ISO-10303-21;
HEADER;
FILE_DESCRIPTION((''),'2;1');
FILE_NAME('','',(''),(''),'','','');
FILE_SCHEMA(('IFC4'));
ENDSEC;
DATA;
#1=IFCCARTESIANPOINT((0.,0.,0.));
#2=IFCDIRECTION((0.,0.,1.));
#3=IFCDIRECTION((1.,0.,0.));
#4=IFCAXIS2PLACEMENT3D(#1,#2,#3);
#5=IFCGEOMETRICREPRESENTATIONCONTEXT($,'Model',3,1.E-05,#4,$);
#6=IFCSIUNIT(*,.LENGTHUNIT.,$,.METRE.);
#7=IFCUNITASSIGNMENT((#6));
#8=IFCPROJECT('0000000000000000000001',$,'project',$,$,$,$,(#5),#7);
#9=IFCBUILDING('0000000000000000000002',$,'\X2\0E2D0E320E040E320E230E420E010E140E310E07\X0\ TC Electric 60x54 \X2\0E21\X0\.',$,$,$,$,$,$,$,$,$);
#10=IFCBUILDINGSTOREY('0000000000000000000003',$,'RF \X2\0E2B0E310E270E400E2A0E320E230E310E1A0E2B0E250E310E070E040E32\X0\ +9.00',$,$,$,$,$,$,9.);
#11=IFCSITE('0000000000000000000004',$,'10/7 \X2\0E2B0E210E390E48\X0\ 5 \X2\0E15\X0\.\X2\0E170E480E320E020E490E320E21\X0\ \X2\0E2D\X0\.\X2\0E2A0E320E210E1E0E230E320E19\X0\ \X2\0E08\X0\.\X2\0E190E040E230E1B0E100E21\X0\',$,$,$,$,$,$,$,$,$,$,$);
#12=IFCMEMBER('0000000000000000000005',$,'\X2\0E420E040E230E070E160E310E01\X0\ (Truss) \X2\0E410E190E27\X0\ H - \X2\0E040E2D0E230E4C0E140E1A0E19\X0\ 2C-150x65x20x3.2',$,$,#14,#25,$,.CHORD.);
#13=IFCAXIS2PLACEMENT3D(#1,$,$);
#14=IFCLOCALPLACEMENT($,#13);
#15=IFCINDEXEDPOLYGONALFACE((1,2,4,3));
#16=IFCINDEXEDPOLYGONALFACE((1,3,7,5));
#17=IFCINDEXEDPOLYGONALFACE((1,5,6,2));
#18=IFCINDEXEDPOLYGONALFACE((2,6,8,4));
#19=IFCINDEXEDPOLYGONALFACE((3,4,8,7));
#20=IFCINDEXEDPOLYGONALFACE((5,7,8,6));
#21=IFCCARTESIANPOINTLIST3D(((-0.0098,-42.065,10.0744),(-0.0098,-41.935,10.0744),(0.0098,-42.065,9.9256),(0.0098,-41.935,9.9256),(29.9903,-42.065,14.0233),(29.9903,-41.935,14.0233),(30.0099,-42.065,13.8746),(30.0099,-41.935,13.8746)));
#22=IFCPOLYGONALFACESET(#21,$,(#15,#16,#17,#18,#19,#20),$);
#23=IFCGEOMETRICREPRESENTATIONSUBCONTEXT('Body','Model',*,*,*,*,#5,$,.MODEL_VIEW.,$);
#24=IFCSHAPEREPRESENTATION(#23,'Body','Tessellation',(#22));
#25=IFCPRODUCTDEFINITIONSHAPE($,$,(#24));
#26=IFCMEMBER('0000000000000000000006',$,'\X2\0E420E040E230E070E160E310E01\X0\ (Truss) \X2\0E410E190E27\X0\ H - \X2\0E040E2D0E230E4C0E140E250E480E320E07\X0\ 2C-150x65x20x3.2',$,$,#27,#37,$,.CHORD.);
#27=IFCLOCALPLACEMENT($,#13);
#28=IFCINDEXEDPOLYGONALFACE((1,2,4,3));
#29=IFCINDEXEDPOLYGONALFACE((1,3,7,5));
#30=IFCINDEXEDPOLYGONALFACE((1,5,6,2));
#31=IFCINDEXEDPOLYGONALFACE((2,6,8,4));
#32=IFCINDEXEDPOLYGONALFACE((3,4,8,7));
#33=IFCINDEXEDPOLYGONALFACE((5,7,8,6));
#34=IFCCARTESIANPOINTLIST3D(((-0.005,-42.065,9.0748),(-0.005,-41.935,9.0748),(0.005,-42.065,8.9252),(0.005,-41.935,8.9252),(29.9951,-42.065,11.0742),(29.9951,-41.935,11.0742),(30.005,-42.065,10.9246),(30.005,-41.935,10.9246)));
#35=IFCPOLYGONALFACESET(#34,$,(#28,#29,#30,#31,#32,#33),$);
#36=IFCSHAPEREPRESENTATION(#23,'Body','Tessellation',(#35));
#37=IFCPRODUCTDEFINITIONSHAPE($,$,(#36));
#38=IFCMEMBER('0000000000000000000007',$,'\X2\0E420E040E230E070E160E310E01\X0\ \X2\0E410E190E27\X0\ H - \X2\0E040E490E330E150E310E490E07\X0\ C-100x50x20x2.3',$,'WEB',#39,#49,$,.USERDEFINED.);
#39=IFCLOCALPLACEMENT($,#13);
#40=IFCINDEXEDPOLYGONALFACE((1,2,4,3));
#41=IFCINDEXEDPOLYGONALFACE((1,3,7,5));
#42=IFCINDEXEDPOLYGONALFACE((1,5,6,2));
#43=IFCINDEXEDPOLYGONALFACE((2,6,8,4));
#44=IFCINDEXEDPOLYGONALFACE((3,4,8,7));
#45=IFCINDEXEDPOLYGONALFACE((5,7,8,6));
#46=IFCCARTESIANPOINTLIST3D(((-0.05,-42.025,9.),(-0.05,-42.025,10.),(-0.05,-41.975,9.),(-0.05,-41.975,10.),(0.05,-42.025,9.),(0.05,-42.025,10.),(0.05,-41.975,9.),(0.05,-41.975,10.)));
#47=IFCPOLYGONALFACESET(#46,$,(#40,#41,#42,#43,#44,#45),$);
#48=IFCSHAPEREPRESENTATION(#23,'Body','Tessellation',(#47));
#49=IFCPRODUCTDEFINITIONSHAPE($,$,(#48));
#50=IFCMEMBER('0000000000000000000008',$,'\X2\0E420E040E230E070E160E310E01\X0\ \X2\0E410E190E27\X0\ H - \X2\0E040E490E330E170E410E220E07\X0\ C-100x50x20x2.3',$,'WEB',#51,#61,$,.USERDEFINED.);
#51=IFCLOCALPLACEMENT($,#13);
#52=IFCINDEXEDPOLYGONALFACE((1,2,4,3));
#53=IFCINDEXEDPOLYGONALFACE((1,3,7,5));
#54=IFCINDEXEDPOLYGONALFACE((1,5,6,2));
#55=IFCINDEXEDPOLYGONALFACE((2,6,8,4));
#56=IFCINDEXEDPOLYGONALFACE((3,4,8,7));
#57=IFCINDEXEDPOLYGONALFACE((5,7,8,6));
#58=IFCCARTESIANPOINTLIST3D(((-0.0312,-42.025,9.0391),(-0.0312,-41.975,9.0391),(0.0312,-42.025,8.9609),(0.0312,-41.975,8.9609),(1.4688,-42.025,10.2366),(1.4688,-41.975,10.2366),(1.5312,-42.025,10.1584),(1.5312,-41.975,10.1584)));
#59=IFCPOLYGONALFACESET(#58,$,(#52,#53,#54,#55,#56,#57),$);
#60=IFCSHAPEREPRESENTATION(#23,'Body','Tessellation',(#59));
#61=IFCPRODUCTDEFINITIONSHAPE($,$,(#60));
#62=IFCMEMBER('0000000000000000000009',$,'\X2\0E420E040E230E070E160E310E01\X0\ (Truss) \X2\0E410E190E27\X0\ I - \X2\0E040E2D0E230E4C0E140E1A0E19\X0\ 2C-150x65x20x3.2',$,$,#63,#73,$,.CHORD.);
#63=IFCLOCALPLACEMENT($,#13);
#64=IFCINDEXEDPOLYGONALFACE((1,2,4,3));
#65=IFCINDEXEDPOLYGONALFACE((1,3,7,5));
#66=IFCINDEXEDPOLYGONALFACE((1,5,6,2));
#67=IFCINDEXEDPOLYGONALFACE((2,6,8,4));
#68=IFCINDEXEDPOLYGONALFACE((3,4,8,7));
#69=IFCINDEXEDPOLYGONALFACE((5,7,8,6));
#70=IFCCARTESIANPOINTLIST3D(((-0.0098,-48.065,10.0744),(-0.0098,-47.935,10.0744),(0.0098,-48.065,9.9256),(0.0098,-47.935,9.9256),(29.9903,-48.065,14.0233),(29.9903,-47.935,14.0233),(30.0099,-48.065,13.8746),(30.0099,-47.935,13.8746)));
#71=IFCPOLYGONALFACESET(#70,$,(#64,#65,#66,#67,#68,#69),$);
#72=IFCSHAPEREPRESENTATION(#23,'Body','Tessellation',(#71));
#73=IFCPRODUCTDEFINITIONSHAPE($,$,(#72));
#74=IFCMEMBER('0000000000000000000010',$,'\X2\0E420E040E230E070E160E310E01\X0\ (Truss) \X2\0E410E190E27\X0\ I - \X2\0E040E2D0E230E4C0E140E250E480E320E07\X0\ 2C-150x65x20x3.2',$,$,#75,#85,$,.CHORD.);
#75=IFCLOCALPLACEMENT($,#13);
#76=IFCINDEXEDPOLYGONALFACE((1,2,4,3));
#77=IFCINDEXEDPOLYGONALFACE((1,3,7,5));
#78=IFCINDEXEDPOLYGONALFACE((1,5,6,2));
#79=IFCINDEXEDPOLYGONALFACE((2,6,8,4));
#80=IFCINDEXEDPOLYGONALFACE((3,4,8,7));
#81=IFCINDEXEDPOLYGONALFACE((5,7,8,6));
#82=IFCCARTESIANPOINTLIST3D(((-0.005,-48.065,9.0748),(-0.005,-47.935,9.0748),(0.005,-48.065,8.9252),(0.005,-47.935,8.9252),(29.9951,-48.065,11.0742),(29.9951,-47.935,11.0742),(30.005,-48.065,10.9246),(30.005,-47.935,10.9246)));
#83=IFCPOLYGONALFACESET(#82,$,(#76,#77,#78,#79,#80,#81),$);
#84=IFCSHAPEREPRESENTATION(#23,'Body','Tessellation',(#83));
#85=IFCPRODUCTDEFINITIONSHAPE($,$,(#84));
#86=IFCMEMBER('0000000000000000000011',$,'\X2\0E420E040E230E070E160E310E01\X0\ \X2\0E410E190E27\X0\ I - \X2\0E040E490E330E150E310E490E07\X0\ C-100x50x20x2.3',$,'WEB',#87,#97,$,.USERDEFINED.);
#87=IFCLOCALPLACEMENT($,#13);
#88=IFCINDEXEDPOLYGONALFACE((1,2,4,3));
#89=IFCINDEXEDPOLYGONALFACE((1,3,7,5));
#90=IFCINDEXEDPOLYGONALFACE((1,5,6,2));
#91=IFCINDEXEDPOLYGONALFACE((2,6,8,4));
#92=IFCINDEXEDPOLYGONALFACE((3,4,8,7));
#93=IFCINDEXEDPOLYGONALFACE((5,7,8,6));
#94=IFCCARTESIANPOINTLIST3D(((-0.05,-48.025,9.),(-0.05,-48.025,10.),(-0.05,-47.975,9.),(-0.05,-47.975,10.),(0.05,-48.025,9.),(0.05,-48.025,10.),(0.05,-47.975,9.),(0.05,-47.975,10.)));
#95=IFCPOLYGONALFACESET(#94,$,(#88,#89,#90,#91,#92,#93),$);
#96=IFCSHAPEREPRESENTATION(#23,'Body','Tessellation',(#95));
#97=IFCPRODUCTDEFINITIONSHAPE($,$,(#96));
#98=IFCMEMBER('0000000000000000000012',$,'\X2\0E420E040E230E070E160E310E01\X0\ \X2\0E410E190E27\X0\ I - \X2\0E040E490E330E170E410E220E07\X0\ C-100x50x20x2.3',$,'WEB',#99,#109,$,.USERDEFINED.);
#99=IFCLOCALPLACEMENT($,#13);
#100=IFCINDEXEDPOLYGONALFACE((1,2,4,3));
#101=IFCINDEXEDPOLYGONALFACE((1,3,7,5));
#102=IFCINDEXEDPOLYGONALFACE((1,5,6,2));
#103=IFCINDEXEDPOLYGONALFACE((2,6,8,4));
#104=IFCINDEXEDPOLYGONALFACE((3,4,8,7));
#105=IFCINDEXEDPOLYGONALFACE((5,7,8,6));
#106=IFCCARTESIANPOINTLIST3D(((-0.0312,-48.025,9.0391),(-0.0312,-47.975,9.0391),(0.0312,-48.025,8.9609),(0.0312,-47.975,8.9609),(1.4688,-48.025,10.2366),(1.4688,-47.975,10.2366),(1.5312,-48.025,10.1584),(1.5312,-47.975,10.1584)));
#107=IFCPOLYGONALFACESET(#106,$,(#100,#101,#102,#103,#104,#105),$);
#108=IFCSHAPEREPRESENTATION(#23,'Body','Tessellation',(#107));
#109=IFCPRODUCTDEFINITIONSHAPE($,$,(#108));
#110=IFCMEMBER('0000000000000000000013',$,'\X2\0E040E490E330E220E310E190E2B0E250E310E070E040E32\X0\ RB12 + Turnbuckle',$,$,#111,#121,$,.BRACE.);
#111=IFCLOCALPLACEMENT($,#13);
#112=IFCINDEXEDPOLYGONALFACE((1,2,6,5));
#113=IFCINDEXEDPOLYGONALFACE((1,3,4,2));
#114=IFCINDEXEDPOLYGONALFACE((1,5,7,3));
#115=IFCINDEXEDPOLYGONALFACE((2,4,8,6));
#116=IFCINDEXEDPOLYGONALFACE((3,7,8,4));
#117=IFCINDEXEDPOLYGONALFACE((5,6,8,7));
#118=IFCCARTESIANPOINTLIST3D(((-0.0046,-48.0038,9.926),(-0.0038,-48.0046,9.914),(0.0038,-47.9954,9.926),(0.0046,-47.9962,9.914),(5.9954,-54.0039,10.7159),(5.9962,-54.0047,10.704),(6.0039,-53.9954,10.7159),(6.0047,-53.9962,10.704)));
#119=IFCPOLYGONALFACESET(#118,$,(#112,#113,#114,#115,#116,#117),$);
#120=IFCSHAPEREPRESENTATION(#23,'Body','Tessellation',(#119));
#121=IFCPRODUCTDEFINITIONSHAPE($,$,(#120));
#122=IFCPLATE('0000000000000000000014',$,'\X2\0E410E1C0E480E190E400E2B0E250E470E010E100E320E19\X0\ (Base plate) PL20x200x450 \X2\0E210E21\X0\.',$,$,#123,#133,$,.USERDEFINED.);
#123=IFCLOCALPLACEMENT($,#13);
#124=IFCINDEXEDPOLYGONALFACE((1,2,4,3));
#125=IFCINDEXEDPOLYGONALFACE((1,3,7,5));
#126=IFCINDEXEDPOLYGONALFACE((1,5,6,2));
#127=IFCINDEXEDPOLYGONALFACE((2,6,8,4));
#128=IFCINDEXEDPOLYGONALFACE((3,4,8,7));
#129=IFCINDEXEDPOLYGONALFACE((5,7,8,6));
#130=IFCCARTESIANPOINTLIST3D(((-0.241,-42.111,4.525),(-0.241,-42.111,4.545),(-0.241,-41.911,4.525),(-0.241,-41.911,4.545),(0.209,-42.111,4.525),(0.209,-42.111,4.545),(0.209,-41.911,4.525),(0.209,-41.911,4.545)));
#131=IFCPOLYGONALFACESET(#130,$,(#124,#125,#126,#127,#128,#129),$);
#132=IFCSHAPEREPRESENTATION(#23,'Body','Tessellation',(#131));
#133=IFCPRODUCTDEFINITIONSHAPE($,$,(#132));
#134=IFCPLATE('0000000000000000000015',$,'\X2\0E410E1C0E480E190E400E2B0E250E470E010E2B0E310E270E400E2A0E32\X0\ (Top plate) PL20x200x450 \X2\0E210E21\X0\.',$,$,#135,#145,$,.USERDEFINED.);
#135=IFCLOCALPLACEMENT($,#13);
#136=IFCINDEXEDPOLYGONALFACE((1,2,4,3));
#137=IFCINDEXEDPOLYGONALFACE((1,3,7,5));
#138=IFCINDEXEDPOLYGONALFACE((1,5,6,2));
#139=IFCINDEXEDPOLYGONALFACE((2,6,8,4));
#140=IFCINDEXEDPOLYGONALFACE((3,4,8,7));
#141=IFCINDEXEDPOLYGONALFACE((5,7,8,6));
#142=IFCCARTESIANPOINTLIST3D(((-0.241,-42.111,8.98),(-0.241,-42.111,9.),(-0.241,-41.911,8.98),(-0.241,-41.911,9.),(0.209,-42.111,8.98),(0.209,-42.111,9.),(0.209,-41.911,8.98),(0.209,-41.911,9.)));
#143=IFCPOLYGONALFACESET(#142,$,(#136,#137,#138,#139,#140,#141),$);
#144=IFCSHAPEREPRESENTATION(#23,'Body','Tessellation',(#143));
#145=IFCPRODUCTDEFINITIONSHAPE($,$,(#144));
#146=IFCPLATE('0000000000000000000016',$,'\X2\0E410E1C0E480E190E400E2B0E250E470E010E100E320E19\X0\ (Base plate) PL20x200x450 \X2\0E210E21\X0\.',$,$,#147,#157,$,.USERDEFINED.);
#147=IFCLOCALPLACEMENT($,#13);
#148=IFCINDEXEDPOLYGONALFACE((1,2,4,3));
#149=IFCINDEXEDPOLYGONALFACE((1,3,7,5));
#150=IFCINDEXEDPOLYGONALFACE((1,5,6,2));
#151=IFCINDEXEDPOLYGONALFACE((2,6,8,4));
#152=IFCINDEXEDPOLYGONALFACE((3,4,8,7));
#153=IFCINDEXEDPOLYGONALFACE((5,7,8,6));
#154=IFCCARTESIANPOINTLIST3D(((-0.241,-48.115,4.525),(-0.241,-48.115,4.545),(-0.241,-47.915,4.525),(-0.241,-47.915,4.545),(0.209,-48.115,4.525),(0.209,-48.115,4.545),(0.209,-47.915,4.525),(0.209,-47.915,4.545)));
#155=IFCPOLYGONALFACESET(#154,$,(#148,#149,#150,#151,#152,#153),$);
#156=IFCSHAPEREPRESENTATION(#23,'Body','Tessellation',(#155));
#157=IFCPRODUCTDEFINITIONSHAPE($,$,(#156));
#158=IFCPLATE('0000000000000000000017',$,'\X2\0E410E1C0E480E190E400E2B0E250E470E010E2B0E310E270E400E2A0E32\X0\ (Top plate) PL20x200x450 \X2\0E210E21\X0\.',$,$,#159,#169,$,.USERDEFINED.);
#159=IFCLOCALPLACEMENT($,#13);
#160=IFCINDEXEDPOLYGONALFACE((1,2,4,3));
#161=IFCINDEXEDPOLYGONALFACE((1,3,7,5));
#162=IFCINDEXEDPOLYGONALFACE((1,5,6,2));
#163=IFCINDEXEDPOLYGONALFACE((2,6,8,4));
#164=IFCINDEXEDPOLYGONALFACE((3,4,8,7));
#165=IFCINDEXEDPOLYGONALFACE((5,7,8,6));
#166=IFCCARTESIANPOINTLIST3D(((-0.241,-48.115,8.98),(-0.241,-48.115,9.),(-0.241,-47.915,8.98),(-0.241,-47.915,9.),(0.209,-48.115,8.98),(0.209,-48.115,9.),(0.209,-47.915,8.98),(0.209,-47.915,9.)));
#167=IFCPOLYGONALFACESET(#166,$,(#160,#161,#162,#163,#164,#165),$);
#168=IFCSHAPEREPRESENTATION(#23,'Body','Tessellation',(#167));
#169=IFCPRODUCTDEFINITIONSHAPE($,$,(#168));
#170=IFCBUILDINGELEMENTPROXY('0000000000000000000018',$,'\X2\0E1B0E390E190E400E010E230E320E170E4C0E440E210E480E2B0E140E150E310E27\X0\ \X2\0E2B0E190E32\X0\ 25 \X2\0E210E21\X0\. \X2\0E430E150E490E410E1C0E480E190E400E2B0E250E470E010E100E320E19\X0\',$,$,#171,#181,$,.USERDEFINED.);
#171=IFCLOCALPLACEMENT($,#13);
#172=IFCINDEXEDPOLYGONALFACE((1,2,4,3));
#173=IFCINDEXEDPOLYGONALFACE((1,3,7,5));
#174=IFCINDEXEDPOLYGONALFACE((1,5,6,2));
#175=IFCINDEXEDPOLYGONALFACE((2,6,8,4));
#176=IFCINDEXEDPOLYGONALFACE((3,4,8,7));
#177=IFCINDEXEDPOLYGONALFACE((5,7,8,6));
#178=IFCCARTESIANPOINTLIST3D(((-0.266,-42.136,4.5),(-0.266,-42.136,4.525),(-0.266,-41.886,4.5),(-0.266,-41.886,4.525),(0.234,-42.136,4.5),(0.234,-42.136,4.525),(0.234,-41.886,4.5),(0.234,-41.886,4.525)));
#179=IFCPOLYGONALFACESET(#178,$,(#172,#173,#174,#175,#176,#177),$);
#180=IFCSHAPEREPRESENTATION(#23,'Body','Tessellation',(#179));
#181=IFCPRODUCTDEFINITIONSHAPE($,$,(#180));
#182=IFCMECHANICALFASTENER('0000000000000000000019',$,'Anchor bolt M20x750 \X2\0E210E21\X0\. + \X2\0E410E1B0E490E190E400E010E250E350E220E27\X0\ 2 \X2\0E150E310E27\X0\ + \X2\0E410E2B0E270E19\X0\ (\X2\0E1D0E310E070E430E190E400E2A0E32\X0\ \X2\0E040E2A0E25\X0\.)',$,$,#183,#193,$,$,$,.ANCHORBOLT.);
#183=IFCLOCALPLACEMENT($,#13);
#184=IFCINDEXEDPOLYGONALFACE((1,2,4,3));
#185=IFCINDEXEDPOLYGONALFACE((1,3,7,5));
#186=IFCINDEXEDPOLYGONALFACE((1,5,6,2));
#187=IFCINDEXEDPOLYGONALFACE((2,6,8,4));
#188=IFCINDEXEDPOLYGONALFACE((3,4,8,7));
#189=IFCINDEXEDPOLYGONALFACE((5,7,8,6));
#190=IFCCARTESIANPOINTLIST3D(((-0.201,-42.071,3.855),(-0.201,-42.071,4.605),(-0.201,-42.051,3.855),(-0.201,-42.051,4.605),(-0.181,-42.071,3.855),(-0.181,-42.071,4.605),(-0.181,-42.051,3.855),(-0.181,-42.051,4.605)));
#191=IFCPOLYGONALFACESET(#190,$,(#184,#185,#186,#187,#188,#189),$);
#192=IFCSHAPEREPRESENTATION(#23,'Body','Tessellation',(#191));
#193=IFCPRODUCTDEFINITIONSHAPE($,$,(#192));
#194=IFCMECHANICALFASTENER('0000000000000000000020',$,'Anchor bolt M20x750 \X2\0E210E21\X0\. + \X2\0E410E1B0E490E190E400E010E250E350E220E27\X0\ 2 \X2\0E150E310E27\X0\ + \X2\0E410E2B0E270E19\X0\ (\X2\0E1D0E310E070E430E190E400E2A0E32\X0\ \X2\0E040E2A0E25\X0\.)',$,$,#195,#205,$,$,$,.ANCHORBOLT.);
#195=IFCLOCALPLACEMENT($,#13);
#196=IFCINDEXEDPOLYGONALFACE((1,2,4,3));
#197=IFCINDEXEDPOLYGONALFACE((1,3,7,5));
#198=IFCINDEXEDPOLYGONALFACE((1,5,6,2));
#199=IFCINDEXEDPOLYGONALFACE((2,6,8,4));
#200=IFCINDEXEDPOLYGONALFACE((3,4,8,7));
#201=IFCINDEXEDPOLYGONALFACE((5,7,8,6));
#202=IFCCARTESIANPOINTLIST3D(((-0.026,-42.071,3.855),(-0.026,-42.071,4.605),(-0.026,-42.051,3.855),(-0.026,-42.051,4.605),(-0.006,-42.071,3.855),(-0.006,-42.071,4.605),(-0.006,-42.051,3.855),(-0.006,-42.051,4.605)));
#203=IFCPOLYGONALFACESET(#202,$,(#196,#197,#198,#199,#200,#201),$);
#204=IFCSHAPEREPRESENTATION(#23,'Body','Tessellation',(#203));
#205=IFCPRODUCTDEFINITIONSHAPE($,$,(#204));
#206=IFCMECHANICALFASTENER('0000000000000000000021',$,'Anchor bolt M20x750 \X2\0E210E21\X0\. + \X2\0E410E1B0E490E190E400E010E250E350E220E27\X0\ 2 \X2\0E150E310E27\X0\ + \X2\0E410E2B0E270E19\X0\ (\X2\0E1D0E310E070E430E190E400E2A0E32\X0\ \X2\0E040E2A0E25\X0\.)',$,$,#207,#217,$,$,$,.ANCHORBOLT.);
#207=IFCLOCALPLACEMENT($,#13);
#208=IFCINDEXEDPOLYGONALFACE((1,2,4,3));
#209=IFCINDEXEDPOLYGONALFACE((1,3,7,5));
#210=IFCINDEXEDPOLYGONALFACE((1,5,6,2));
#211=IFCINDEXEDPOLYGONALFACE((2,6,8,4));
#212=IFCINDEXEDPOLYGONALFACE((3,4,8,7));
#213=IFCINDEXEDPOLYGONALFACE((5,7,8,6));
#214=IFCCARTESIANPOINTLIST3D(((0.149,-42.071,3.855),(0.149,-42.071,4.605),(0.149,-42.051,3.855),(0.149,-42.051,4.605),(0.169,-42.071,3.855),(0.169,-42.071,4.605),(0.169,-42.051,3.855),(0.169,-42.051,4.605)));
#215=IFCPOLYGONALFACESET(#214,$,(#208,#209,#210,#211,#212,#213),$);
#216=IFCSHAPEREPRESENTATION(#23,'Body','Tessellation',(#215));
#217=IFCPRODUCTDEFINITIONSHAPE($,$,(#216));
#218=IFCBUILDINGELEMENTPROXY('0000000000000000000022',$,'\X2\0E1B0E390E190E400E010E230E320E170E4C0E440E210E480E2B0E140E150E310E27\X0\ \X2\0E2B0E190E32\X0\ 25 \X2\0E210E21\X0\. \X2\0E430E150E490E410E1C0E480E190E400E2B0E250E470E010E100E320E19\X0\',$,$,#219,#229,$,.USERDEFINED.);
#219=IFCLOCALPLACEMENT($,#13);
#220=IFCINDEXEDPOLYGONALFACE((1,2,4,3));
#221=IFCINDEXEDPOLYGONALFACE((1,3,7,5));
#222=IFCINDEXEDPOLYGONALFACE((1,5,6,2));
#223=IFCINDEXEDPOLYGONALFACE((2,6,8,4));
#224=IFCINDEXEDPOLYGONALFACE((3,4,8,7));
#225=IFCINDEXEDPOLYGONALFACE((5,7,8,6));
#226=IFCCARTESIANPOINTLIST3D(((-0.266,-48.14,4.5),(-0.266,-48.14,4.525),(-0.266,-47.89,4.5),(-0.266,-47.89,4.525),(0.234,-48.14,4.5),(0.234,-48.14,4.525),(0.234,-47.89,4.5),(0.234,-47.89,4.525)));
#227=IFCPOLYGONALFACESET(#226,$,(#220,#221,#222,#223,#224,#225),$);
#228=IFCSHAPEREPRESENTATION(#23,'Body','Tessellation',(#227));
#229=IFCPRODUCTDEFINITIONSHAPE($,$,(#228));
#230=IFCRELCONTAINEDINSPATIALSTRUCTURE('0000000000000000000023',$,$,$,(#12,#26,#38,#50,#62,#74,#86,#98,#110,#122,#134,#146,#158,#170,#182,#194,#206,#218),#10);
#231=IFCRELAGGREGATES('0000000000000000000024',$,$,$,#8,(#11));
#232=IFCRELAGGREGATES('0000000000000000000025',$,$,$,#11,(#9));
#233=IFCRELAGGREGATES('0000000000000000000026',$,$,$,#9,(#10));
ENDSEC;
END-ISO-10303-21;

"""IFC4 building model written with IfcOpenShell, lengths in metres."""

from ifc_helpers import new_model, si_unit, frame, origin, origin_with_axes, origin_2d, place, context, subcontext, project, spatial, rectangle, extrude, element, save


model = new_model("IFC4")

# Units and contexts
model_context = context("Model", 3, precision=1e-05, world=origin_with_axes())
body_context = subcontext(model_context, "Body", "Model", "MODEL_VIEW")
ifc_project = project(units=[si_unit("LENGTHUNIT", "METRE")], contexts=[model_context])

# Site, building, storey
site = spatial("IfcSite", under=ifc_project, Name="10/7 หมู่ 5 ต.ท่าข้าม อ.สามพราน จ.นครปฐม")
building = spatial("IfcBuilding", under=site, Name="อาคารโกดัง TC Electric 60x54 ม.")
storey = spatial("IfcBuildingStorey", under=building, Name="RF หัวเสารับหลังคา +9.00", Elevation=9.0)

# Members
member_1_placement = place(None, frame((0.0, -42.0, 10.0), z_axis=(0.9914, 0.0, 0.1305), x_axis=(0.0, -1.0, 0.0)))
element("IfcMember", 1, at=member_1_placement, inside=storey, Name="โครงถัก (Truss) แนว H - คอร์ดบน 2C-150x65x20x3.2", PredefinedType="CHORD", context=body_context, shape_type="SweptSolid", body=[
    extrude(rectangle(XDim=0.13, YDim=0.15, at=origin_2d()), origin(), (0.0, 0.0, 1.0), 30.2589),
])
member_2_placement = place(None, frame((0.0, -42.0, 9.0), z_axis=(0.9978, 0.0, 0.0665), x_axis=(0.0, -1.0, 0.0)))
element("IfcMember", 2, at=member_2_placement, inside=storey, Name="โครงถัก (Truss) แนว H - คอร์ดล่าง 2C-150x65x20x3.2", PredefinedType="CHORD", context=body_context, shape_type="SweptSolid", body=[
    extrude(rectangle(XDim=0.13, YDim=0.15, at=origin_2d()), origin(), (0.0, 0.0, 1.0), 30.0666),
])
member_3_placement = place(None, frame((0.0, -42.0, 9.0), z_axis=(0.0, 0.0, 1.0), x_axis=(0.0, 1.0, 0.0)))
element("IfcMember", 3, at=member_3_placement, inside=storey, Name="โครงถัก แนว H - ค้ำตั้ง C-100x50x20x2.3", ObjectType="WEB", PredefinedType="USERDEFINED", context=body_context, shape_type="SweptSolid", body=[
    extrude(rectangle(XDim=0.05, YDim=0.1, at=origin_2d()), origin(), (0.0, 0.0, 1.0), 1.0),
])
member_4_placement = place(None, frame((0.0, -42.0, 9.0), z_axis=(0.7815, 0.0, 0.6239), x_axis=(0.0, -1.0, 0.0)))
element("IfcMember", 4, at=member_4_placement, inside=storey, Name="โครงถัก แนว H - ค้ำทแยง C-100x50x20x2.3", ObjectType="WEB", PredefinedType="USERDEFINED", context=body_context, shape_type="SweptSolid", body=[
    extrude(rectangle(XDim=0.05, YDim=0.1, at=origin_2d()), origin(), (0.0, 0.0, 1.0), 1.9194),
])
member_5_placement = place(None, frame((0.0, -48.0, 10.0), z_axis=(0.9914, 0.0, 0.1305), x_axis=(0.0, -1.0, 0.0)))
element("IfcMember", 5, at=member_5_placement, inside=storey, Name="โครงถัก (Truss) แนว I - คอร์ดบน 2C-150x65x20x3.2", PredefinedType="CHORD", context=body_context, shape_type="SweptSolid", body=[
    extrude(rectangle(XDim=0.13, YDim=0.15, at=origin_2d()), origin(), (0.0, 0.0, 1.0), 30.2589),
])
member_6_placement = place(None, frame((0.0, -48.0, 9.0), z_axis=(0.9978, 0.0, 0.0665), x_axis=(0.0, -1.0, 0.0)))
element("IfcMember", 6, at=member_6_placement, inside=storey, Name="โครงถัก (Truss) แนว I - คอร์ดล่าง 2C-150x65x20x3.2", PredefinedType="CHORD", context=body_context, shape_type="SweptSolid", body=[
    extrude(rectangle(XDim=0.13, YDim=0.15, at=origin_2d()), origin(), (0.0, 0.0, 1.0), 30.0666),
])
member_7_placement = place(None, frame((0.0, -48.0, 9.0), z_axis=(0.0, 0.0, 1.0), x_axis=(0.0, 1.0, 0.0)))
element("IfcMember", 7, at=member_7_placement, inside=storey, Name="โครงถัก แนว I - ค้ำตั้ง C-100x50x20x2.3", ObjectType="WEB", PredefinedType="USERDEFINED", context=body_context, shape_type="SweptSolid", body=[
    extrude(rectangle(XDim=0.05, YDim=0.1, at=origin_2d()), origin(), (0.0, 0.0, 1.0), 1.0),
])
member_8_placement = place(None, frame((0.0, -48.0, 9.0), z_axis=(0.7815, 0.0, 0.6239), x_axis=(0.0, -1.0, 0.0)))
element("IfcMember", 8, at=member_8_placement, inside=storey, Name="โครงถัก แนว I - ค้ำทแยง C-100x50x20x2.3", ObjectType="WEB", PredefinedType="USERDEFINED", context=body_context, shape_type="SweptSolid", body=[
    extrude(rectangle(XDim=0.05, YDim=0.1, at=origin_2d()), origin(), (0.0, 0.0, 1.0), 1.9194),
])
member_9_placement = place(None, frame((0.0, -48.0, 9.92), z_axis=(0.7041, -0.7041, 0.0927), x_axis=(-0.7071, -0.7071, 0.0)))
element("IfcMember", 9, at=member_9_placement, inside=storey, Name="ค้ำยันหลังคา RB12 + Turnbuckle", PredefinedType="BRACE", context=body_context, shape_type="SweptSolid", body=[
    extrude(rectangle(XDim=0.012, YDim=0.012, at=origin_2d()), origin(), (0.0, 0.0, 1.0), 8.522),
])

# Plates
for number, where, z_axis, x_axis, name in (
    (10, (-0.016, -42.011, 4.525), (0.0, 0.0, 1.0), (1.0, 0.0, 0.0), "แผ่นเหล็กฐาน (Base plate) PL20x200x450 มม."),
    (11, (-0.016, -42.011, 8.98), (0.0, 0.0, 1.0), (1.0, 0.0, 0.0), "แผ่นเหล็กหัวเสา (Top plate) PL20x200x450 มม."),
    (12, (-0.016, -48.015, 4.525), (0.0, 0.0, 1.0), (1.0, 0.0, 0.0), "แผ่นเหล็กฐาน (Base plate) PL20x200x450 มม."),
    (13, (-0.016, -48.015, 8.98), (0.0, 0.0, 1.0), (1.0, 0.0, 0.0), "แผ่นเหล็กหัวเสา (Top plate) PL20x200x450 มม."),
):
    element("IfcPlate", number, at=place(None, frame(where, z_axis=z_axis, x_axis=x_axis)), inside=storey, Name=name, PredefinedType="USERDEFINED", context=body_context, shape_type="SweptSolid", body=[
        extrude(rectangle(XDim=0.45, YDim=0.2, at=origin_2d()), origin(), (0.0, 0.0, 1.0), 0.02),
    ])

# Building element proxy
proxy_1_placement = place(None, frame((-0.016, -42.011, 4.5), z_axis=(0.0, 0.0, 1.0), x_axis=(1.0, 0.0, 0.0)))
element("IfcBuildingElementProxy", 14, at=proxy_1_placement, inside=storey, Name="ปูนเกราท์ไม่หดตัว หนา 25 มม. ใต้แผ่นเหล็กฐาน", PredefinedType="USERDEFINED", context=body_context, shape_type="SweptSolid", body=[
    extrude(rectangle(XDim=0.5, YDim=0.25, at=origin_2d()), origin(), (0.0, 0.0, 1.0), 0.025),
])

# Mechanical fasteners
for number, where, z_axis, x_axis, name in (
    (15, (-0.191, -42.061, 3.855), (0.0, 0.0, 1.0), (1.0, 0.0, 0.0), "Anchor bolt M20x750 มม. + แป้นเกลียว 2 ตัว + แหวน (ฝังในเสา คสล.)"),
    (16, (-0.016, -42.061, 3.855), (0.0, 0.0, 1.0), (1.0, 0.0, 0.0), "Anchor bolt M20x750 มม. + แป้นเกลียว 2 ตัว + แหวน (ฝังในเสา คสล.)"),
    (17, (0.159, -42.061, 3.855), (0.0, 0.0, 1.0), (1.0, 0.0, 0.0), "Anchor bolt M20x750 มม. + แป้นเกลียว 2 ตัว + แหวน (ฝังในเสา คสล.)"),
):
    element("IfcMechanicalFastener", number, at=place(None, frame(where, z_axis=z_axis, x_axis=x_axis)), inside=storey, Name=name, PredefinedType="ANCHORBOLT", context=body_context, shape_type="SweptSolid", body=[
        extrude(rectangle(XDim=0.02, YDim=0.02, at=origin_2d()), origin(), (0.0, 0.0, 1.0), 0.75),
    ])

# Building element proxy
proxy_2_placement = place(None, frame((-0.016, -48.015, 4.5), z_axis=(0.0, 0.0, 1.0), x_axis=(1.0, 0.0, 0.0)))
element("IfcBuildingElementProxy", 18, at=proxy_2_placement, inside=storey, Name="ปูนเกราท์ไม่หดตัว หนา 25 มม. ใต้แผ่นเหล็กฐาน", PredefinedType="USERDEFINED", context=body_context, shape_type="SweptSolid", body=[
    extrude(rectangle(XDim=0.5, YDim=0.25, at=origin_2d()), origin(), (0.0, 0.0, 1.0), 0.025),
])

save(model, "model.ifc")
